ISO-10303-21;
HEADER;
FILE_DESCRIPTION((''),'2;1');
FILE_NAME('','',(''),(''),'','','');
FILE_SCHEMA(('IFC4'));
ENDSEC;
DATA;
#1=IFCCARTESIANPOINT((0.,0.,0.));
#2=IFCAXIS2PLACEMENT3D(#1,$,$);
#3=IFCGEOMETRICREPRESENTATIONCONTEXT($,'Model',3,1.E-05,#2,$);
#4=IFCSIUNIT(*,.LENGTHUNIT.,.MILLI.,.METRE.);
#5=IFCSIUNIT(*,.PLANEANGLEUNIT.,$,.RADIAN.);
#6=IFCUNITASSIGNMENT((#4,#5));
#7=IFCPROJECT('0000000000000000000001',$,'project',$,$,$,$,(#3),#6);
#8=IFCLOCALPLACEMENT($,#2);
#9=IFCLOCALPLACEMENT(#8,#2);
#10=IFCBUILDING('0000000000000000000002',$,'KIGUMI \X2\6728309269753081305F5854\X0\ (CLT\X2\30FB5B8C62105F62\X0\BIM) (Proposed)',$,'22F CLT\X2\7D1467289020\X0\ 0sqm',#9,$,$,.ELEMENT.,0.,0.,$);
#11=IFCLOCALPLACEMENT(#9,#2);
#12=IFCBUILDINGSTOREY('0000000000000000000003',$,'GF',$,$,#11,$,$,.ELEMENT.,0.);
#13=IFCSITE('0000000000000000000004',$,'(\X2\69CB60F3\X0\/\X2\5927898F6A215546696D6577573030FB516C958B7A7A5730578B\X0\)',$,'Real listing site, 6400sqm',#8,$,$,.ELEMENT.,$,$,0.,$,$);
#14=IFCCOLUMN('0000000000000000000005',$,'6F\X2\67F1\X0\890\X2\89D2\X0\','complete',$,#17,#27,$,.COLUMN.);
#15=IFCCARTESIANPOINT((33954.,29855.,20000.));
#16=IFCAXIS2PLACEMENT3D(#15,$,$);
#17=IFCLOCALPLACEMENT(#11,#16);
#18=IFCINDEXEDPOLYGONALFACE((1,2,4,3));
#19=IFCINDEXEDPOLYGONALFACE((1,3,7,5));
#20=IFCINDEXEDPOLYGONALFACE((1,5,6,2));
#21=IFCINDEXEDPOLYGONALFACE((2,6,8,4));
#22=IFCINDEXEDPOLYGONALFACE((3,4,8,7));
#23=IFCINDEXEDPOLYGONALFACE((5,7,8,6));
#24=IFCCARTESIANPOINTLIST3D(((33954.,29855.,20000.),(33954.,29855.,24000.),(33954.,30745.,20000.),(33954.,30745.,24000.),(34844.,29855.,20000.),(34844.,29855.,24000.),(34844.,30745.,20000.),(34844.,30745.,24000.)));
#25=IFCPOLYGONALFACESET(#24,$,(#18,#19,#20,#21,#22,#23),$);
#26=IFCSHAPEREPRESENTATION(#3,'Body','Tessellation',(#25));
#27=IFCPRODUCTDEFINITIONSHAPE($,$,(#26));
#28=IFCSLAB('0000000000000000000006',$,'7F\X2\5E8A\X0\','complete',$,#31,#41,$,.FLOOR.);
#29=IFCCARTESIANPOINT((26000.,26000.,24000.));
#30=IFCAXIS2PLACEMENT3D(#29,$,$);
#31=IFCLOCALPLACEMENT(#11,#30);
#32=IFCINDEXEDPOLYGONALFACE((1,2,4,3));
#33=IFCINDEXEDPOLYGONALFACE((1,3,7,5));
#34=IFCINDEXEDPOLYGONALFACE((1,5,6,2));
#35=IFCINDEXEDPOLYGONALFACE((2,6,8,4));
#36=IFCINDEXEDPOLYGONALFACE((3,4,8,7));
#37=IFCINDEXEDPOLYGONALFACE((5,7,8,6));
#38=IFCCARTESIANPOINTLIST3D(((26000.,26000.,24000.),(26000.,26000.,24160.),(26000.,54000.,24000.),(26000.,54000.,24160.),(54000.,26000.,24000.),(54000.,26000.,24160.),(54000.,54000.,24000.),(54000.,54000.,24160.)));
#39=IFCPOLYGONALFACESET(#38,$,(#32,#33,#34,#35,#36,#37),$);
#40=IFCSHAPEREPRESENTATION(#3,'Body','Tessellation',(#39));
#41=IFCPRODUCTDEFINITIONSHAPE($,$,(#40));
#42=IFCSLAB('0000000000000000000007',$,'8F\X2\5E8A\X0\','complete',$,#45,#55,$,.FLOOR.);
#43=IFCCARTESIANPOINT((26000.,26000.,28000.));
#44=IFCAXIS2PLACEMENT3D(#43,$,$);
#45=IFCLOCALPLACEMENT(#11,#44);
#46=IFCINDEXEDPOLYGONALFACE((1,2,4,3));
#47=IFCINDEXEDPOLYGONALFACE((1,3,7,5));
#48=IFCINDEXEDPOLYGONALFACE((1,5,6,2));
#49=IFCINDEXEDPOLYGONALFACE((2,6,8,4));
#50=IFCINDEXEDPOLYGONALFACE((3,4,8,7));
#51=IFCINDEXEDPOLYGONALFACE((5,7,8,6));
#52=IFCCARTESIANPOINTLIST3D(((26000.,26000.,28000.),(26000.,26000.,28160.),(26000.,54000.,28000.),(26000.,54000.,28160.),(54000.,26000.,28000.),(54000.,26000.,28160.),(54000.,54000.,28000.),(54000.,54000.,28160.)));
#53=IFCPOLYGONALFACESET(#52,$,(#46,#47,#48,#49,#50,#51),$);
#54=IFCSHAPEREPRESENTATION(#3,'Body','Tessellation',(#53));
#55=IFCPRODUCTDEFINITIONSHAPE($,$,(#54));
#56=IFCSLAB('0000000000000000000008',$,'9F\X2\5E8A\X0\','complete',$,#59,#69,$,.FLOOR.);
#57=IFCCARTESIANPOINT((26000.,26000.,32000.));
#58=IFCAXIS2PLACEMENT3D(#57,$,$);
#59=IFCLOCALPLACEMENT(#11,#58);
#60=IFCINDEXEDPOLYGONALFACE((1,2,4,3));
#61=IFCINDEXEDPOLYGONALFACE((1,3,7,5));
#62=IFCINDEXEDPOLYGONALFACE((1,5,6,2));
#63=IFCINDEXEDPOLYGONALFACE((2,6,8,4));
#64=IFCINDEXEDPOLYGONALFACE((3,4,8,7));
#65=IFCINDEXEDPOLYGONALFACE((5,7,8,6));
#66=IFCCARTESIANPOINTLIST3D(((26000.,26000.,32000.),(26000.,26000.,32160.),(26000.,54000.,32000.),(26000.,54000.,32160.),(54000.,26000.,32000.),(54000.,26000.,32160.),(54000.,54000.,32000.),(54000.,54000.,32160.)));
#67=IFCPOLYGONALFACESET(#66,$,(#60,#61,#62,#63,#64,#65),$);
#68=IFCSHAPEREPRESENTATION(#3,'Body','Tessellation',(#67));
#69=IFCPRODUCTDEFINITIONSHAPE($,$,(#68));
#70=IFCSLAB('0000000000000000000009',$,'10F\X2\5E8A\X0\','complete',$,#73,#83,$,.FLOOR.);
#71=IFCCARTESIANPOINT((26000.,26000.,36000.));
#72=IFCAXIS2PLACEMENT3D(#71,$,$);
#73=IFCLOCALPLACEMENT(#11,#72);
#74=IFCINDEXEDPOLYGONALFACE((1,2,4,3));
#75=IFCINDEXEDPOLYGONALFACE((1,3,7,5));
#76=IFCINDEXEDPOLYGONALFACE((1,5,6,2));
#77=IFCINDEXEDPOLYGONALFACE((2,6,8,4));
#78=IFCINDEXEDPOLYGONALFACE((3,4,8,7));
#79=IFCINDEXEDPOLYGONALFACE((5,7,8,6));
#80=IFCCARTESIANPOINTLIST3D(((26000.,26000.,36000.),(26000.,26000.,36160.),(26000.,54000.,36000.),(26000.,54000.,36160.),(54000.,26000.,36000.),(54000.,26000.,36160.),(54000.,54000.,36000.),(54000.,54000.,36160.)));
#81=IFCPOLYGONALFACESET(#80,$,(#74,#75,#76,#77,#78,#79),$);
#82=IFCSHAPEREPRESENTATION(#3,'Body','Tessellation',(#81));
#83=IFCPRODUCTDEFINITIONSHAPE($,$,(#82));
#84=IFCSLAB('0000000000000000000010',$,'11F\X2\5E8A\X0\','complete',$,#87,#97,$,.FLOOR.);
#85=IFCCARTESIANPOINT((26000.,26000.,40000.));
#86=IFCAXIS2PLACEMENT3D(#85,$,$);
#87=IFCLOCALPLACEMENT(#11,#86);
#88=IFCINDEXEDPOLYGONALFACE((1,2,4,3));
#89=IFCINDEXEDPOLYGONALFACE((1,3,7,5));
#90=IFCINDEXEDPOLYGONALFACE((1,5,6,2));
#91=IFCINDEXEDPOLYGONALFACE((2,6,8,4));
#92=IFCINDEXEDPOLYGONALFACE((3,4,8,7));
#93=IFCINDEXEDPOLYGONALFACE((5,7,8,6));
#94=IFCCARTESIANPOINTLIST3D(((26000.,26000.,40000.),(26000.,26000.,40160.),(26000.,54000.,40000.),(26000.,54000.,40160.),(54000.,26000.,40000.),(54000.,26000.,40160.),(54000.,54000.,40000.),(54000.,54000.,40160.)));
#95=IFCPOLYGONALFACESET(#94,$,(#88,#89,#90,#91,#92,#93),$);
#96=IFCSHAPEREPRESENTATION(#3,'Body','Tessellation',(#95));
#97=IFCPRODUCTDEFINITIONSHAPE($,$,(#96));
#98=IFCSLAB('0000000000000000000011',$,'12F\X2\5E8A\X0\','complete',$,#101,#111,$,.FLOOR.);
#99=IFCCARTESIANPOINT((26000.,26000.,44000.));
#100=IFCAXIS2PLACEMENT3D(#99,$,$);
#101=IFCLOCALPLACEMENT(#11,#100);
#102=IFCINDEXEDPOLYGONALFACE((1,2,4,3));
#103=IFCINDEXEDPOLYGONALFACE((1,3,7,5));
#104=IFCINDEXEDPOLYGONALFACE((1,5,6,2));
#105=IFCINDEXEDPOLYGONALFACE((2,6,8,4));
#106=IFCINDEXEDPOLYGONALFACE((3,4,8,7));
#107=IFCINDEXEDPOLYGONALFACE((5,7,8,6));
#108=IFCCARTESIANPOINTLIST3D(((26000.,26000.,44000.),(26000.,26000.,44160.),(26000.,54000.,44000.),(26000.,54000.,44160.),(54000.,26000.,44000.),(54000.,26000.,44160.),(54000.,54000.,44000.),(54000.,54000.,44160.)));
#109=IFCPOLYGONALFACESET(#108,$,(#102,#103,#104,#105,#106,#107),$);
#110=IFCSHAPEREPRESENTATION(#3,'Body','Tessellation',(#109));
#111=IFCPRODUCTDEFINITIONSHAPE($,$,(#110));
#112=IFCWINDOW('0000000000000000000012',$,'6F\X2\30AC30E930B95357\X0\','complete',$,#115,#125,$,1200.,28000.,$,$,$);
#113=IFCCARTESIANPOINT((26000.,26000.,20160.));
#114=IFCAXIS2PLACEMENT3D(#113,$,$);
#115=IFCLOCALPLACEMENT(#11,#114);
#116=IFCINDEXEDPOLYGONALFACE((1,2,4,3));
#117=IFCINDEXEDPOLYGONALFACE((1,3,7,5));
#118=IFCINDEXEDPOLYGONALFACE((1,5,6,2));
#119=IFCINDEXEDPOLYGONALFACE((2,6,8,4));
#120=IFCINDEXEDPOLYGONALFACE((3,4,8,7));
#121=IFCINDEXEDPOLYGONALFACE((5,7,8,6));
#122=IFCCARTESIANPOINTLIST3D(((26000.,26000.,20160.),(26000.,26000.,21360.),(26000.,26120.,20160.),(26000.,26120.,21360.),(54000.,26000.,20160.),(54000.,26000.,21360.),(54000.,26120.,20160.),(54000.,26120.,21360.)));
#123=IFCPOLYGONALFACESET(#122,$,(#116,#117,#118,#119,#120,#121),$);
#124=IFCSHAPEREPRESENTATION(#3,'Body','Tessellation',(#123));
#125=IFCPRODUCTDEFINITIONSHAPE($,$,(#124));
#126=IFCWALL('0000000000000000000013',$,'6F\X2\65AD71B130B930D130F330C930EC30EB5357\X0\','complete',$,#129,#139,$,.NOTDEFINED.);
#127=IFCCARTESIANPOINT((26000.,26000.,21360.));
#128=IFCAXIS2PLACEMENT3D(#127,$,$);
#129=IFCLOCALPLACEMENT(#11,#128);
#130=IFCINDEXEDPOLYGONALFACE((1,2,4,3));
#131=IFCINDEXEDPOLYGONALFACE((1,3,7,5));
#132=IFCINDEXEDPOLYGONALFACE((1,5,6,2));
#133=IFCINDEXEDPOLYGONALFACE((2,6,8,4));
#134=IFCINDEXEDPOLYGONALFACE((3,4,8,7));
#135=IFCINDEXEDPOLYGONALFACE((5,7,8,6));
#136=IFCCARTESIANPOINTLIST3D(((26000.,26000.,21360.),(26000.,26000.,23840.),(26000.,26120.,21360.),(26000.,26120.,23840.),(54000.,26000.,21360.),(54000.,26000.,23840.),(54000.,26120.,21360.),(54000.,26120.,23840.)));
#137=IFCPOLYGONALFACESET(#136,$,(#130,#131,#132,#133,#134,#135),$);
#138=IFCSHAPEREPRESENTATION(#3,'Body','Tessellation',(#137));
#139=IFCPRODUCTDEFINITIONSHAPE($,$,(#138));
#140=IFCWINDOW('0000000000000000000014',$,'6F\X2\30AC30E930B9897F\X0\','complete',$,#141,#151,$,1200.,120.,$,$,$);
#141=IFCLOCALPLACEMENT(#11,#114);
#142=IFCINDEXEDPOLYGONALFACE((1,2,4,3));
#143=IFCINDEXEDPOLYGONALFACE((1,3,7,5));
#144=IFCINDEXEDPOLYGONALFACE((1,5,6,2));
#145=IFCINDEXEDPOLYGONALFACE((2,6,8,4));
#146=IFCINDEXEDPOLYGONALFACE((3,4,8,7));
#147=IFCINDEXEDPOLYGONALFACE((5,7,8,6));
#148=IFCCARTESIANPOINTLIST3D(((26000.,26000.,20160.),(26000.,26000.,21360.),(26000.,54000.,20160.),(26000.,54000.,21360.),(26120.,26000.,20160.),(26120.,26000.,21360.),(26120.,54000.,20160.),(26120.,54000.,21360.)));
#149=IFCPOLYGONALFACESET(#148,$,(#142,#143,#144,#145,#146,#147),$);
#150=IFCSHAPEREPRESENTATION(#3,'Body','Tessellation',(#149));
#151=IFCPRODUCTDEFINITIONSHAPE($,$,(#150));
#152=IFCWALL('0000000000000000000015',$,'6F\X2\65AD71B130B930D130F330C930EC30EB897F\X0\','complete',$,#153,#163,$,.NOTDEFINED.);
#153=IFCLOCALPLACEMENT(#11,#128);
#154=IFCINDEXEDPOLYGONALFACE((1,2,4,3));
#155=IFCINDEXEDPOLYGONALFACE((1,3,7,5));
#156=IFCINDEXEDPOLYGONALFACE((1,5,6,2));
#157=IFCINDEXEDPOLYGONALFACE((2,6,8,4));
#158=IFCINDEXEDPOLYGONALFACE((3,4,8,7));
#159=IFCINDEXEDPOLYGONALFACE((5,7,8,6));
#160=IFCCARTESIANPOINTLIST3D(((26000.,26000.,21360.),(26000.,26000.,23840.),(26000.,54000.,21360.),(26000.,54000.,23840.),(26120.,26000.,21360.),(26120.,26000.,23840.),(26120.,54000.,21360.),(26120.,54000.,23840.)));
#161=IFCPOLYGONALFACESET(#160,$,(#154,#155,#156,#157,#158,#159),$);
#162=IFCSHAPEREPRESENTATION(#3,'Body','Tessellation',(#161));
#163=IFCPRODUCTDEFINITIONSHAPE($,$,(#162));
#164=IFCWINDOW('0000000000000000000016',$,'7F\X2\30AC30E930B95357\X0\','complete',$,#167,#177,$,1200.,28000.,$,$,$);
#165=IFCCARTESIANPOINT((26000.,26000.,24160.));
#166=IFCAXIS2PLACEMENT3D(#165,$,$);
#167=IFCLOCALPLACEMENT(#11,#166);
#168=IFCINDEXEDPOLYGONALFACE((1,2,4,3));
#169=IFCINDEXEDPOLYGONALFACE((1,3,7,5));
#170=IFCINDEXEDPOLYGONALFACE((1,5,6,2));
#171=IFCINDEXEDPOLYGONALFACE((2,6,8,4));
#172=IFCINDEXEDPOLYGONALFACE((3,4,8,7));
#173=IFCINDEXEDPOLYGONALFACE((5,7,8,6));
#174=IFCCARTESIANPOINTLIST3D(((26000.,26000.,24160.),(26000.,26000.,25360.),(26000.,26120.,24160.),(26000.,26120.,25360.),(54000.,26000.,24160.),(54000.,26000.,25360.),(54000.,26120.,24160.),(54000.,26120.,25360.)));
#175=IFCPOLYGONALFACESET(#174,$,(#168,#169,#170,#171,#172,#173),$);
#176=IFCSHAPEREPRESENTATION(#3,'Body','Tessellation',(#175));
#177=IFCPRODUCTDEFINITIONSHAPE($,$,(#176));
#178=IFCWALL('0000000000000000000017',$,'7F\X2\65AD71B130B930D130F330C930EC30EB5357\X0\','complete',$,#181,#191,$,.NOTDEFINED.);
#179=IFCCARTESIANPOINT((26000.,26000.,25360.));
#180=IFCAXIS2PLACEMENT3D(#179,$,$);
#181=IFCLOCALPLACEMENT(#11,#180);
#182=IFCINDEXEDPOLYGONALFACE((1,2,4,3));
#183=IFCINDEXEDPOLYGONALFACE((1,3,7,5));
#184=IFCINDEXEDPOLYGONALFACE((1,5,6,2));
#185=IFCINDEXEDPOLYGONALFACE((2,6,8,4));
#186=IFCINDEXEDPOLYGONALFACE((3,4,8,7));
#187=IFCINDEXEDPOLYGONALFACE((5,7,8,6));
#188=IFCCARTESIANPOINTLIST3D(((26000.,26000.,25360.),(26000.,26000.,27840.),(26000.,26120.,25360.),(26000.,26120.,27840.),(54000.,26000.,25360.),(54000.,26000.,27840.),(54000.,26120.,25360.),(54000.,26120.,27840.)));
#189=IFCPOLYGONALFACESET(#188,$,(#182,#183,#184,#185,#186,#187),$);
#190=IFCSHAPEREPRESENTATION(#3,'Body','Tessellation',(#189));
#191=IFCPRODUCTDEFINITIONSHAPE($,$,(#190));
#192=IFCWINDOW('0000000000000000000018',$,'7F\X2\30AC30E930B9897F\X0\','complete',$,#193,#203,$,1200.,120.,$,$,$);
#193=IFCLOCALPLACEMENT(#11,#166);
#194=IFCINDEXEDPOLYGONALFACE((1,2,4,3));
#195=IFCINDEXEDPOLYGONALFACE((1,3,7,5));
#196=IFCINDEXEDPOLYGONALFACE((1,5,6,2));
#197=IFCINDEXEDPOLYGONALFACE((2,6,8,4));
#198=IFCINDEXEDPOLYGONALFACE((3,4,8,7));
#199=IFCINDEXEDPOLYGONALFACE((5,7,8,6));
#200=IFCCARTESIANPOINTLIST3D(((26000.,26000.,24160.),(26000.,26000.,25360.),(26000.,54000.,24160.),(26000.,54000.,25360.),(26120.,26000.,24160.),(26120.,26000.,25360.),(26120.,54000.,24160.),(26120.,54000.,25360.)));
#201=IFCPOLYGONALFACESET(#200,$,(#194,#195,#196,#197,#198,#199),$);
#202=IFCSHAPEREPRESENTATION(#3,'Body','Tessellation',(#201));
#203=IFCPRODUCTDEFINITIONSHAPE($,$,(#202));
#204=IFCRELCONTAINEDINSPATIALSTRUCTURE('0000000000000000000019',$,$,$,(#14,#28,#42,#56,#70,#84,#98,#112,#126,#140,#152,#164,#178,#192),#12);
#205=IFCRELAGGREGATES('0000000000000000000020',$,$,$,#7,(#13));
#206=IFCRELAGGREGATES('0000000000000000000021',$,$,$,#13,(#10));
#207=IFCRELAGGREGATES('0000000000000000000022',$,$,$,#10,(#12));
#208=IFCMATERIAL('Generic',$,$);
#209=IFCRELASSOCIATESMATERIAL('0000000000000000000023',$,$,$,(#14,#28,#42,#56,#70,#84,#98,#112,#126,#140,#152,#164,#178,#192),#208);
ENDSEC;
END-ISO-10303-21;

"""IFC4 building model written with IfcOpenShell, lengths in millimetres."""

from ifc_helpers import new_model, si_unit, frame, frame_2d, origin, place, context, project, spatial, rectangle, extrude, material, element, save


model = new_model("IFC4")

# Units and contexts
model_context = context("Model", 3, precision=1e-05, world=origin())
ifc_project = project(units=[si_unit("LENGTHUNIT", "METRE", prefix="MILLI"), si_unit("PLANEANGLEUNIT", "RADIAN")], contexts=[model_context])

# Site, building, storey
site_placement = place(None, origin())
site = spatial("IfcSite", under=ifc_project, at=site_placement, Name="(構想/大規模商業敷地・公開空地型)", ObjectType="Real listing site, 6400sqm", CompositionType="ELEMENT", RefElevation=0.0)
building_placement = place(site_placement, origin())
building = spatial("IfcBuilding", under=site, at=building_placement, Name="KIGUMI 木を極めた塔 (CLT・完成形BIM) (Proposed)", ObjectType="22F CLT純木造 0sqm", CompositionType="ELEMENT", ElevationOfRefHeight=0.0, ElevationOfTerrain=0.0)
storey_placement = place(building_placement, origin())
storey = spatial("IfcBuildingStorey", under=building, at=storey_placement, Name="GF", CompositionType="ELEMENT", Elevation=0.0)

# Column
ifc_material = material(Name="Generic")
column_placement = place(storey_placement, frame((33954.0, 29855.0, 20000.0)))
element("IfcColumn", 1, at=column_placement, inside=storey, material=ifc_material, Name="6F柱890角", Description="complete", PredefinedType="COLUMN", context=model_context, shape_type="SweptSolid", body=[
    extrude(rectangle(XDim=890.0, YDim=890.0, at=frame_2d((445.0, 445.0))), frame((33954.0, 29855.0, 20000.0)), (0.0, 0.0, 1.0), 4000.0),
])

# Slabs
slab_1_placement = place(storey_placement, frame((26000.0, 26000.0, 24000.0)))
element("IfcSlab", 2, at=slab_1_placement, inside=storey, material=ifc_material, Name="7F床", Description="complete", PredefinedType="FLOOR", context=model_context, shape_type="SweptSolid", body=[
    extrude(rectangle(XDim=28000.0, YDim=28000.0, at=frame_2d((14000.0, 14000.0))), frame((26000.0, 26000.0, 24000.0)), (0.0, 0.0, 1.0), 160.0),
])
slab_2_placement = place(storey_placement, frame((26000.0, 26000.0, 28000.0)))
element("IfcSlab", 3, at=slab_2_placement, inside=storey, material=ifc_material, Name="8F床", Description="complete", PredefinedType="FLOOR", context=model_context, shape_type="SweptSolid", body=[
    extrude(rectangle(XDim=28000.0, YDim=28000.0, at=frame_2d((14000.0, 14000.0))), frame((26000.0, 26000.0, 28000.0)), (0.0, 0.0, 1.0), 160.0),
])
slab_3_placement = place(storey_placement, frame((26000.0, 26000.0, 32000.0)))
element("IfcSlab", 4, at=slab_3_placement, inside=storey, material=ifc_material, Name="9F床", Description="complete", PredefinedType="FLOOR", context=model_context, shape_type="SweptSolid", body=[
    extrude(rectangle(XDim=28000.0, YDim=28000.0, at=frame_2d((14000.0, 14000.0))), frame((26000.0, 26000.0, 32000.0)), (0.0, 0.0, 1.0), 160.0),
])
slab_4_placement = place(storey_placement, frame((26000.0, 26000.0, 36000.0)))
element("IfcSlab", 5, at=slab_4_placement, inside=storey, material=ifc_material, Name="10F床", Description="complete", PredefinedType="FLOOR", context=model_context, shape_type="SweptSolid", body=[
    extrude(rectangle(XDim=28000.0, YDim=28000.0, at=frame_2d((14000.0, 14000.0))), frame((26000.0, 26000.0, 36000.0)), (0.0, 0.0, 1.0), 160.0),
])
slab_5_placement = place(storey_placement, frame((26000.0, 26000.0, 40000.0)))
element("IfcSlab", 6, at=slab_5_placement, inside=storey, material=ifc_material, Name="11F床", Description="complete", PredefinedType="FLOOR", context=model_context, shape_type="SweptSolid", body=[
    extrude(rectangle(XDim=28000.0, YDim=28000.0, at=frame_2d((14000.0, 14000.0))), frame((26000.0, 26000.0, 40000.0)), (0.0, 0.0, 1.0), 160.0),
])
slab_6_placement = place(storey_placement, frame((26000.0, 26000.0, 44000.0)))
element("IfcSlab", 7, at=slab_6_placement, inside=storey, material=ifc_material, Name="12F床", Description="complete", PredefinedType="FLOOR", context=model_context, shape_type="SweptSolid", body=[
    extrude(rectangle(XDim=28000.0, YDim=28000.0, at=frame_2d((14000.0, 14000.0))), frame((26000.0, 26000.0, 44000.0)), (0.0, 0.0, 1.0), 160.0),
])

# Window
window_1_placement = place(storey_placement, frame((26000.0, 26000.0, 20160.0)))
element("IfcWindow", 8, at=window_1_placement, inside=storey, material=ifc_material, Name="6Fガラス南", Description="complete", OverallHeight=1200.0, OverallWidth=28000.0, context=model_context, shape_type="SweptSolid", body=[
    extrude(rectangle(XDim=28000.0, YDim=120.0, at=frame_2d((14000.0, 60.0))), frame((26000.0, 26000.0, 20160.0)), (0.0, 0.0, 1.0), 1200.0),
])

# Wall
wall_1_placement = place(storey_placement, frame((26000.0, 26000.0, 21360.0)))
element("IfcWall", 9, at=wall_1_placement, inside=storey, material=ifc_material, Name="6F断熱スパンドレル南", Description="complete", PredefinedType="NOTDEFINED", context=model_context, shape_type="SweptSolid", body=[
    extrude(rectangle(XDim=28000.0, YDim=120.0, at=frame_2d((14000.0, 60.0))), frame((26000.0, 26000.0, 21360.0)), (0.0, 0.0, 1.0), 2480.0),
])

# Window
window_2_placement = place(storey_placement, frame((26000.0, 26000.0, 20160.0)))
element("IfcWindow", 10, at=window_2_placement, inside=storey, material=ifc_material, Name="6Fガラス西", Description="complete", OverallHeight=1200.0, OverallWidth=120.0, context=model_context, shape_type="SweptSolid", body=[
    extrude(rectangle(XDim=120.0, YDim=28000.0, at=frame_2d((60.0, 14000.0))), frame((26000.0, 26000.0, 20160.0)), (0.0, 0.0, 1.0), 1200.0),
])

# Wall
wall_2_placement = place(storey_placement, frame((26000.0, 26000.0, 21360.0)))
element("IfcWall", 11, at=wall_2_placement, inside=storey, material=ifc_material, Name="6F断熱スパンドレル西", Description="complete", PredefinedType="NOTDEFINED", context=model_context, shape_type="SweptSolid", body=[
    extrude(rectangle(XDim=120.0, YDim=28000.0, at=frame_2d((60.0, 14000.0))), frame((26000.0, 26000.0, 21360.0)), (0.0, 0.0, 1.0), 2480.0),
])

# Window
window_3_placement = place(storey_placement, frame((26000.0, 26000.0, 24160.0)))
element("IfcWindow", 12, at=window_3_placement, inside=storey, material=ifc_material, Name="7Fガラス南", Description="complete", OverallHeight=1200.0, OverallWidth=28000.0, context=model_context, shape_type="SweptSolid", body=[
    extrude(rectangle(XDim=28000.0, YDim=120.0, at=frame_2d((14000.0, 60.0))), frame((26000.0, 26000.0, 24160.0)), (0.0, 0.0, 1.0), 1200.0),
])

# Wall
wall_3_placement = place(storey_placement, frame((26000.0, 26000.0, 25360.0)))
element("IfcWall", 13, at=wall_3_placement, inside=storey, material=ifc_material, Name="7F断熱スパンドレル南", Description="complete", PredefinedType="NOTDEFINED", context=model_context, shape_type="SweptSolid", body=[
    extrude(rectangle(XDim=28000.0, YDim=120.0, at=frame_2d((14000.0, 60.0))), frame((26000.0, 26000.0, 25360.0)), (0.0, 0.0, 1.0), 2480.0),
])

# Window
window_4_placement = place(storey_placement, frame((26000.0, 26000.0, 24160.0)))
element("IfcWindow", 14, at=window_4_placement, inside=storey, material=ifc_material, Name="7Fガラス西", Description="complete", OverallHeight=1200.0, OverallWidth=120.0, context=model_context, shape_type="SweptSolid", body=[
    extrude(rectangle(XDim=120.0, YDim=28000.0, at=frame_2d((60.0, 14000.0))), frame((26000.0, 26000.0, 24160.0)), (0.0, 0.0, 1.0), 1200.0),
])

save(model, "model.ifc")
